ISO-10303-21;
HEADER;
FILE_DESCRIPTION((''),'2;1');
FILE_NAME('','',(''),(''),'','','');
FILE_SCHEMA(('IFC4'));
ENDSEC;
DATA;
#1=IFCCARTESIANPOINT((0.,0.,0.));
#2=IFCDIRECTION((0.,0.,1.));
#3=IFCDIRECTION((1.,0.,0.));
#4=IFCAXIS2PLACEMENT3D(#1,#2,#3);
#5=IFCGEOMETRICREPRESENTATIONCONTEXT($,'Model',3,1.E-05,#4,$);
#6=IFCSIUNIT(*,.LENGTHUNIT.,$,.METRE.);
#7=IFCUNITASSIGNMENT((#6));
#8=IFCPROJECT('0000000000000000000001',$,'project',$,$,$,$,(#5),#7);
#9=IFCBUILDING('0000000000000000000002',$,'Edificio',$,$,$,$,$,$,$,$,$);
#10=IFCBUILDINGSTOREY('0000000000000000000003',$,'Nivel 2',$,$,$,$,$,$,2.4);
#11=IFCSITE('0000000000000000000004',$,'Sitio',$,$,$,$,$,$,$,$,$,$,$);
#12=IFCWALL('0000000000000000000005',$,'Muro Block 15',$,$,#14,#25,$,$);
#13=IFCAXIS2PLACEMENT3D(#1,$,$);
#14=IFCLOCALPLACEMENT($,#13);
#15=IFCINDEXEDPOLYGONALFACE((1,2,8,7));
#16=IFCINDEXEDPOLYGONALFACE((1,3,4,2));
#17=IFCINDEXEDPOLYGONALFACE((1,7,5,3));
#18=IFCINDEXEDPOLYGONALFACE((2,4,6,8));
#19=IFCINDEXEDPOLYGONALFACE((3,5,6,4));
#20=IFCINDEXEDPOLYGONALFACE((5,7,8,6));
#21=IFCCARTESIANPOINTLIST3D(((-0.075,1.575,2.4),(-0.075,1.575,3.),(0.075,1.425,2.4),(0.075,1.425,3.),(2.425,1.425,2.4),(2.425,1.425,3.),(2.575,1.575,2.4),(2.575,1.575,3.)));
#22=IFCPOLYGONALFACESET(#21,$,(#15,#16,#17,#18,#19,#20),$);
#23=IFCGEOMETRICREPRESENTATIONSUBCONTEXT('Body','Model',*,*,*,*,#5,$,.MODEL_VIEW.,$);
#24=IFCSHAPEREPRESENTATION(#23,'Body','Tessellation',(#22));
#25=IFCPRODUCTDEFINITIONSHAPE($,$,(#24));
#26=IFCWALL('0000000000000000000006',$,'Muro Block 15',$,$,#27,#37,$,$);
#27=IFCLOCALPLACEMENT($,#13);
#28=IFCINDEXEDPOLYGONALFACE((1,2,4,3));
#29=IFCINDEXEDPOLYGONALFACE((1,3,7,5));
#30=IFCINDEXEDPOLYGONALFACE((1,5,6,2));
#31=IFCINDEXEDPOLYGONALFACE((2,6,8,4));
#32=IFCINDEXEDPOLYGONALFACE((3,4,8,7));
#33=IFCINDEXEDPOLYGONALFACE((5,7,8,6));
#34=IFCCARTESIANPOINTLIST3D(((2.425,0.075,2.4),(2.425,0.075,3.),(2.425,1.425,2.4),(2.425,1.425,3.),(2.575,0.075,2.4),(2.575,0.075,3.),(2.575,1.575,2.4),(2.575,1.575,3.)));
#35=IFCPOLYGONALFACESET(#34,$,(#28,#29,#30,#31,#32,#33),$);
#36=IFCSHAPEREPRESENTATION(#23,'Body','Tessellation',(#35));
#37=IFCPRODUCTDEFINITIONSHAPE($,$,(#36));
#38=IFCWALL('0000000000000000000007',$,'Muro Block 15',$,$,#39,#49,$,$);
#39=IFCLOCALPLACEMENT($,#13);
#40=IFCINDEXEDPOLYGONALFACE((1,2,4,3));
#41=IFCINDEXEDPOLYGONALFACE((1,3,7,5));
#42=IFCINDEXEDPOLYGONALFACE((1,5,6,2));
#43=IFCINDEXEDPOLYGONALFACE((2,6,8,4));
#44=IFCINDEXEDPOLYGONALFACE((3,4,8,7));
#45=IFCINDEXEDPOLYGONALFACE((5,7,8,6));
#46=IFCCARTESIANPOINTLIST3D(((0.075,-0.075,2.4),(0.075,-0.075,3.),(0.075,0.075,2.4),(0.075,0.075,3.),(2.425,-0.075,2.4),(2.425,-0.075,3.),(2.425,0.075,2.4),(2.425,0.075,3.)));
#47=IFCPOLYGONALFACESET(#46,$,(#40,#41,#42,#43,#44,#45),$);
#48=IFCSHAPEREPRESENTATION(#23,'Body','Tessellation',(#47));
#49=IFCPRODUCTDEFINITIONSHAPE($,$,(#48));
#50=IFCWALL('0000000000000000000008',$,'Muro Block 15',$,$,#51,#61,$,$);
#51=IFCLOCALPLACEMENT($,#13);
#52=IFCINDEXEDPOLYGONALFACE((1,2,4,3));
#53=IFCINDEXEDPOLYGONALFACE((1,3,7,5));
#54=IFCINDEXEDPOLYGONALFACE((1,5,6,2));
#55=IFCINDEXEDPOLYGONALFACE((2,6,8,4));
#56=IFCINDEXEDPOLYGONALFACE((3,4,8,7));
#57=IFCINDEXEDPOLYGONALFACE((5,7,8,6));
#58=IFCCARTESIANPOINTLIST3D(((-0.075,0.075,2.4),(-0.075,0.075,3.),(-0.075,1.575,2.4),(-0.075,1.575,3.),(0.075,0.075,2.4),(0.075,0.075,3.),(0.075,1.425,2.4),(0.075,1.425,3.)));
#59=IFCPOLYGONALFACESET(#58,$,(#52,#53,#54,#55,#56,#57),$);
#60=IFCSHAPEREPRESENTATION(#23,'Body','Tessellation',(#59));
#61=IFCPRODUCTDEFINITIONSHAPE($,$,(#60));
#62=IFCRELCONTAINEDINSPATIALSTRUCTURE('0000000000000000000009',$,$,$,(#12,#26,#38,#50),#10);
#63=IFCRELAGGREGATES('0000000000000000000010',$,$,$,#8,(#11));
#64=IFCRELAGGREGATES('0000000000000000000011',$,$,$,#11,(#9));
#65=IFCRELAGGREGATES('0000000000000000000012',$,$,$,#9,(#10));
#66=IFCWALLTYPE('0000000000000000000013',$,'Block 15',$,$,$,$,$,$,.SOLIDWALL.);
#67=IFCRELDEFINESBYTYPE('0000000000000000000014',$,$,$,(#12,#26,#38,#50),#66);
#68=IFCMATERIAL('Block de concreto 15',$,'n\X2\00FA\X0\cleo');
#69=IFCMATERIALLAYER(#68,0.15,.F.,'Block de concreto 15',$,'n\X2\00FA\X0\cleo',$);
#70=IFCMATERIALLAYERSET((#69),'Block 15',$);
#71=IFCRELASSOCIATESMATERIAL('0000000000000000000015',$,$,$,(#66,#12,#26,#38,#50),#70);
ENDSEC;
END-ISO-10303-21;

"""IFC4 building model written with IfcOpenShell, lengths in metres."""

from ifc_helpers import new_model, si_unit, frame, origin_with_axes, place, context, subcontext, project, spatial, indexed_curve, outline, extrude, material, layer, layer_set, layer_usage, type_object, element, save


model = new_model("IFC4")

# Units and contexts
model_context = context("Model", 3, precision=1e-05, world=origin_with_axes())
body_context = subcontext(model_context, "Body", "Model", "MODEL_VIEW")
ifc_project = project(units=[si_unit("LENGTHUNIT", "METRE")], contexts=[model_context])

# Site, building, storey
site = spatial("IfcSite", under=ifc_project, Name="Sitio")
building = spatial("IfcBuilding", under=site, Name="Edificio")
storey = spatial("IfcBuildingStorey", under=building, Name="Nivel 2", Elevation=2.4)

# Walls
ifc_material = material(Name="Block de concreto 15", Category="núcleo")
ifc_layer = layer(ifc_material, 0.15, ventilated=False, Name="Block de concreto 15", Category="núcleo")
ifc_layer_set = layer_set([ifc_layer], Name="Block 15")
ifc_layer_usage_1 = layer_usage(ifc_layer_set, "AXIS2", "POSITIVE", 0.0)
wall_type = type_object("IfcWallType", Name="Block 15", PredefinedType="SOLIDWALL", material=ifc_layer_set)
wall_1_placement = place(None, frame((0.0, 1.5, 2.4), z_axis=(0.0, 0.0, 1.0), x_axis=(1.0, 0.0, 0.0)))
element("IfcWall", 1, at=wall_1_placement, inside=storey, type_object=wall_type, material=ifc_layer_usage_1, Name="Muro Block 15", context=body_context, shape_type="SweptSolid", body=[
    extrude(outline(indexed_curve([(0.075, -0.075), (2.425, -0.075), (2.575, 0.075), (-0.075, 0.075)])), None, (0.0, 0.0, 1.0), 0.6),
])
ifc_layer_usage_2 = layer_usage(ifc_layer_set, "AXIS2", "POSITIVE", 0.0)
wall_2_placement = place(None, frame((2.5, 1.5, 2.4), z_axis=(0.0, 0.0, 1.0), x_axis=(0.0, -1.0, 0.0)))
element("IfcWall", 2, at=wall_2_placement, inside=storey, type_object=wall_type, material=ifc_layer_usage_2, Name="Muro Block 15", context=body_context, shape_type="SweptSolid", body=[
    extrude(outline(indexed_curve([(0.075, -0.075), (-0.075, 0.075), (1.425, 0.075), (1.425, -0.075)])), None, (0.0, 0.0, 1.0), 0.6),
])
ifc_layer_usage_3 = layer_usage(ifc_layer_set, "AXIS2", "POSITIVE", 0.0)
wall_3_placement = place(None, frame((2.5, 0.0, 2.4), z_axis=(0.0, 0.0, 1.0), x_axis=(-1.0, 0.0, 0.0)))
element("IfcWall", 3, at=wall_3_placement, inside=storey, type_object=wall_type, material=ifc_layer_usage_3, Name="Muro Block 15", context=body_context, shape_type="SweptSolid", body=[
    extrude(outline(indexed_curve([(0.075, -0.075), (0.075, 0.075), (2.425, 0.075), (2.425, -0.075)])), None, (0.0, 0.0, 1.0), 0.6),
])
ifc_layer_usage_4 = layer_usage(ifc_layer_set, "AXIS2", "POSITIVE", 0.0)
wall_4_placement = place(None, frame((0.0, 0.0, 2.4), z_axis=(0.0, 0.0, 1.0), x_axis=(0.0, 1.0, 0.0)))
element("IfcWall", 4, at=wall_4_placement, inside=storey, type_object=wall_type, material=ifc_layer_usage_4, Name="Muro Block 15", context=body_context, shape_type="SweptSolid", body=[
    extrude(outline(indexed_curve([(1.575, 0.075), (1.425, -0.075), (0.075, -0.075), (0.075, 0.075)])), None, (0.0, 0.0, 1.0), 0.6),
])

save(model, "model.ifc")
